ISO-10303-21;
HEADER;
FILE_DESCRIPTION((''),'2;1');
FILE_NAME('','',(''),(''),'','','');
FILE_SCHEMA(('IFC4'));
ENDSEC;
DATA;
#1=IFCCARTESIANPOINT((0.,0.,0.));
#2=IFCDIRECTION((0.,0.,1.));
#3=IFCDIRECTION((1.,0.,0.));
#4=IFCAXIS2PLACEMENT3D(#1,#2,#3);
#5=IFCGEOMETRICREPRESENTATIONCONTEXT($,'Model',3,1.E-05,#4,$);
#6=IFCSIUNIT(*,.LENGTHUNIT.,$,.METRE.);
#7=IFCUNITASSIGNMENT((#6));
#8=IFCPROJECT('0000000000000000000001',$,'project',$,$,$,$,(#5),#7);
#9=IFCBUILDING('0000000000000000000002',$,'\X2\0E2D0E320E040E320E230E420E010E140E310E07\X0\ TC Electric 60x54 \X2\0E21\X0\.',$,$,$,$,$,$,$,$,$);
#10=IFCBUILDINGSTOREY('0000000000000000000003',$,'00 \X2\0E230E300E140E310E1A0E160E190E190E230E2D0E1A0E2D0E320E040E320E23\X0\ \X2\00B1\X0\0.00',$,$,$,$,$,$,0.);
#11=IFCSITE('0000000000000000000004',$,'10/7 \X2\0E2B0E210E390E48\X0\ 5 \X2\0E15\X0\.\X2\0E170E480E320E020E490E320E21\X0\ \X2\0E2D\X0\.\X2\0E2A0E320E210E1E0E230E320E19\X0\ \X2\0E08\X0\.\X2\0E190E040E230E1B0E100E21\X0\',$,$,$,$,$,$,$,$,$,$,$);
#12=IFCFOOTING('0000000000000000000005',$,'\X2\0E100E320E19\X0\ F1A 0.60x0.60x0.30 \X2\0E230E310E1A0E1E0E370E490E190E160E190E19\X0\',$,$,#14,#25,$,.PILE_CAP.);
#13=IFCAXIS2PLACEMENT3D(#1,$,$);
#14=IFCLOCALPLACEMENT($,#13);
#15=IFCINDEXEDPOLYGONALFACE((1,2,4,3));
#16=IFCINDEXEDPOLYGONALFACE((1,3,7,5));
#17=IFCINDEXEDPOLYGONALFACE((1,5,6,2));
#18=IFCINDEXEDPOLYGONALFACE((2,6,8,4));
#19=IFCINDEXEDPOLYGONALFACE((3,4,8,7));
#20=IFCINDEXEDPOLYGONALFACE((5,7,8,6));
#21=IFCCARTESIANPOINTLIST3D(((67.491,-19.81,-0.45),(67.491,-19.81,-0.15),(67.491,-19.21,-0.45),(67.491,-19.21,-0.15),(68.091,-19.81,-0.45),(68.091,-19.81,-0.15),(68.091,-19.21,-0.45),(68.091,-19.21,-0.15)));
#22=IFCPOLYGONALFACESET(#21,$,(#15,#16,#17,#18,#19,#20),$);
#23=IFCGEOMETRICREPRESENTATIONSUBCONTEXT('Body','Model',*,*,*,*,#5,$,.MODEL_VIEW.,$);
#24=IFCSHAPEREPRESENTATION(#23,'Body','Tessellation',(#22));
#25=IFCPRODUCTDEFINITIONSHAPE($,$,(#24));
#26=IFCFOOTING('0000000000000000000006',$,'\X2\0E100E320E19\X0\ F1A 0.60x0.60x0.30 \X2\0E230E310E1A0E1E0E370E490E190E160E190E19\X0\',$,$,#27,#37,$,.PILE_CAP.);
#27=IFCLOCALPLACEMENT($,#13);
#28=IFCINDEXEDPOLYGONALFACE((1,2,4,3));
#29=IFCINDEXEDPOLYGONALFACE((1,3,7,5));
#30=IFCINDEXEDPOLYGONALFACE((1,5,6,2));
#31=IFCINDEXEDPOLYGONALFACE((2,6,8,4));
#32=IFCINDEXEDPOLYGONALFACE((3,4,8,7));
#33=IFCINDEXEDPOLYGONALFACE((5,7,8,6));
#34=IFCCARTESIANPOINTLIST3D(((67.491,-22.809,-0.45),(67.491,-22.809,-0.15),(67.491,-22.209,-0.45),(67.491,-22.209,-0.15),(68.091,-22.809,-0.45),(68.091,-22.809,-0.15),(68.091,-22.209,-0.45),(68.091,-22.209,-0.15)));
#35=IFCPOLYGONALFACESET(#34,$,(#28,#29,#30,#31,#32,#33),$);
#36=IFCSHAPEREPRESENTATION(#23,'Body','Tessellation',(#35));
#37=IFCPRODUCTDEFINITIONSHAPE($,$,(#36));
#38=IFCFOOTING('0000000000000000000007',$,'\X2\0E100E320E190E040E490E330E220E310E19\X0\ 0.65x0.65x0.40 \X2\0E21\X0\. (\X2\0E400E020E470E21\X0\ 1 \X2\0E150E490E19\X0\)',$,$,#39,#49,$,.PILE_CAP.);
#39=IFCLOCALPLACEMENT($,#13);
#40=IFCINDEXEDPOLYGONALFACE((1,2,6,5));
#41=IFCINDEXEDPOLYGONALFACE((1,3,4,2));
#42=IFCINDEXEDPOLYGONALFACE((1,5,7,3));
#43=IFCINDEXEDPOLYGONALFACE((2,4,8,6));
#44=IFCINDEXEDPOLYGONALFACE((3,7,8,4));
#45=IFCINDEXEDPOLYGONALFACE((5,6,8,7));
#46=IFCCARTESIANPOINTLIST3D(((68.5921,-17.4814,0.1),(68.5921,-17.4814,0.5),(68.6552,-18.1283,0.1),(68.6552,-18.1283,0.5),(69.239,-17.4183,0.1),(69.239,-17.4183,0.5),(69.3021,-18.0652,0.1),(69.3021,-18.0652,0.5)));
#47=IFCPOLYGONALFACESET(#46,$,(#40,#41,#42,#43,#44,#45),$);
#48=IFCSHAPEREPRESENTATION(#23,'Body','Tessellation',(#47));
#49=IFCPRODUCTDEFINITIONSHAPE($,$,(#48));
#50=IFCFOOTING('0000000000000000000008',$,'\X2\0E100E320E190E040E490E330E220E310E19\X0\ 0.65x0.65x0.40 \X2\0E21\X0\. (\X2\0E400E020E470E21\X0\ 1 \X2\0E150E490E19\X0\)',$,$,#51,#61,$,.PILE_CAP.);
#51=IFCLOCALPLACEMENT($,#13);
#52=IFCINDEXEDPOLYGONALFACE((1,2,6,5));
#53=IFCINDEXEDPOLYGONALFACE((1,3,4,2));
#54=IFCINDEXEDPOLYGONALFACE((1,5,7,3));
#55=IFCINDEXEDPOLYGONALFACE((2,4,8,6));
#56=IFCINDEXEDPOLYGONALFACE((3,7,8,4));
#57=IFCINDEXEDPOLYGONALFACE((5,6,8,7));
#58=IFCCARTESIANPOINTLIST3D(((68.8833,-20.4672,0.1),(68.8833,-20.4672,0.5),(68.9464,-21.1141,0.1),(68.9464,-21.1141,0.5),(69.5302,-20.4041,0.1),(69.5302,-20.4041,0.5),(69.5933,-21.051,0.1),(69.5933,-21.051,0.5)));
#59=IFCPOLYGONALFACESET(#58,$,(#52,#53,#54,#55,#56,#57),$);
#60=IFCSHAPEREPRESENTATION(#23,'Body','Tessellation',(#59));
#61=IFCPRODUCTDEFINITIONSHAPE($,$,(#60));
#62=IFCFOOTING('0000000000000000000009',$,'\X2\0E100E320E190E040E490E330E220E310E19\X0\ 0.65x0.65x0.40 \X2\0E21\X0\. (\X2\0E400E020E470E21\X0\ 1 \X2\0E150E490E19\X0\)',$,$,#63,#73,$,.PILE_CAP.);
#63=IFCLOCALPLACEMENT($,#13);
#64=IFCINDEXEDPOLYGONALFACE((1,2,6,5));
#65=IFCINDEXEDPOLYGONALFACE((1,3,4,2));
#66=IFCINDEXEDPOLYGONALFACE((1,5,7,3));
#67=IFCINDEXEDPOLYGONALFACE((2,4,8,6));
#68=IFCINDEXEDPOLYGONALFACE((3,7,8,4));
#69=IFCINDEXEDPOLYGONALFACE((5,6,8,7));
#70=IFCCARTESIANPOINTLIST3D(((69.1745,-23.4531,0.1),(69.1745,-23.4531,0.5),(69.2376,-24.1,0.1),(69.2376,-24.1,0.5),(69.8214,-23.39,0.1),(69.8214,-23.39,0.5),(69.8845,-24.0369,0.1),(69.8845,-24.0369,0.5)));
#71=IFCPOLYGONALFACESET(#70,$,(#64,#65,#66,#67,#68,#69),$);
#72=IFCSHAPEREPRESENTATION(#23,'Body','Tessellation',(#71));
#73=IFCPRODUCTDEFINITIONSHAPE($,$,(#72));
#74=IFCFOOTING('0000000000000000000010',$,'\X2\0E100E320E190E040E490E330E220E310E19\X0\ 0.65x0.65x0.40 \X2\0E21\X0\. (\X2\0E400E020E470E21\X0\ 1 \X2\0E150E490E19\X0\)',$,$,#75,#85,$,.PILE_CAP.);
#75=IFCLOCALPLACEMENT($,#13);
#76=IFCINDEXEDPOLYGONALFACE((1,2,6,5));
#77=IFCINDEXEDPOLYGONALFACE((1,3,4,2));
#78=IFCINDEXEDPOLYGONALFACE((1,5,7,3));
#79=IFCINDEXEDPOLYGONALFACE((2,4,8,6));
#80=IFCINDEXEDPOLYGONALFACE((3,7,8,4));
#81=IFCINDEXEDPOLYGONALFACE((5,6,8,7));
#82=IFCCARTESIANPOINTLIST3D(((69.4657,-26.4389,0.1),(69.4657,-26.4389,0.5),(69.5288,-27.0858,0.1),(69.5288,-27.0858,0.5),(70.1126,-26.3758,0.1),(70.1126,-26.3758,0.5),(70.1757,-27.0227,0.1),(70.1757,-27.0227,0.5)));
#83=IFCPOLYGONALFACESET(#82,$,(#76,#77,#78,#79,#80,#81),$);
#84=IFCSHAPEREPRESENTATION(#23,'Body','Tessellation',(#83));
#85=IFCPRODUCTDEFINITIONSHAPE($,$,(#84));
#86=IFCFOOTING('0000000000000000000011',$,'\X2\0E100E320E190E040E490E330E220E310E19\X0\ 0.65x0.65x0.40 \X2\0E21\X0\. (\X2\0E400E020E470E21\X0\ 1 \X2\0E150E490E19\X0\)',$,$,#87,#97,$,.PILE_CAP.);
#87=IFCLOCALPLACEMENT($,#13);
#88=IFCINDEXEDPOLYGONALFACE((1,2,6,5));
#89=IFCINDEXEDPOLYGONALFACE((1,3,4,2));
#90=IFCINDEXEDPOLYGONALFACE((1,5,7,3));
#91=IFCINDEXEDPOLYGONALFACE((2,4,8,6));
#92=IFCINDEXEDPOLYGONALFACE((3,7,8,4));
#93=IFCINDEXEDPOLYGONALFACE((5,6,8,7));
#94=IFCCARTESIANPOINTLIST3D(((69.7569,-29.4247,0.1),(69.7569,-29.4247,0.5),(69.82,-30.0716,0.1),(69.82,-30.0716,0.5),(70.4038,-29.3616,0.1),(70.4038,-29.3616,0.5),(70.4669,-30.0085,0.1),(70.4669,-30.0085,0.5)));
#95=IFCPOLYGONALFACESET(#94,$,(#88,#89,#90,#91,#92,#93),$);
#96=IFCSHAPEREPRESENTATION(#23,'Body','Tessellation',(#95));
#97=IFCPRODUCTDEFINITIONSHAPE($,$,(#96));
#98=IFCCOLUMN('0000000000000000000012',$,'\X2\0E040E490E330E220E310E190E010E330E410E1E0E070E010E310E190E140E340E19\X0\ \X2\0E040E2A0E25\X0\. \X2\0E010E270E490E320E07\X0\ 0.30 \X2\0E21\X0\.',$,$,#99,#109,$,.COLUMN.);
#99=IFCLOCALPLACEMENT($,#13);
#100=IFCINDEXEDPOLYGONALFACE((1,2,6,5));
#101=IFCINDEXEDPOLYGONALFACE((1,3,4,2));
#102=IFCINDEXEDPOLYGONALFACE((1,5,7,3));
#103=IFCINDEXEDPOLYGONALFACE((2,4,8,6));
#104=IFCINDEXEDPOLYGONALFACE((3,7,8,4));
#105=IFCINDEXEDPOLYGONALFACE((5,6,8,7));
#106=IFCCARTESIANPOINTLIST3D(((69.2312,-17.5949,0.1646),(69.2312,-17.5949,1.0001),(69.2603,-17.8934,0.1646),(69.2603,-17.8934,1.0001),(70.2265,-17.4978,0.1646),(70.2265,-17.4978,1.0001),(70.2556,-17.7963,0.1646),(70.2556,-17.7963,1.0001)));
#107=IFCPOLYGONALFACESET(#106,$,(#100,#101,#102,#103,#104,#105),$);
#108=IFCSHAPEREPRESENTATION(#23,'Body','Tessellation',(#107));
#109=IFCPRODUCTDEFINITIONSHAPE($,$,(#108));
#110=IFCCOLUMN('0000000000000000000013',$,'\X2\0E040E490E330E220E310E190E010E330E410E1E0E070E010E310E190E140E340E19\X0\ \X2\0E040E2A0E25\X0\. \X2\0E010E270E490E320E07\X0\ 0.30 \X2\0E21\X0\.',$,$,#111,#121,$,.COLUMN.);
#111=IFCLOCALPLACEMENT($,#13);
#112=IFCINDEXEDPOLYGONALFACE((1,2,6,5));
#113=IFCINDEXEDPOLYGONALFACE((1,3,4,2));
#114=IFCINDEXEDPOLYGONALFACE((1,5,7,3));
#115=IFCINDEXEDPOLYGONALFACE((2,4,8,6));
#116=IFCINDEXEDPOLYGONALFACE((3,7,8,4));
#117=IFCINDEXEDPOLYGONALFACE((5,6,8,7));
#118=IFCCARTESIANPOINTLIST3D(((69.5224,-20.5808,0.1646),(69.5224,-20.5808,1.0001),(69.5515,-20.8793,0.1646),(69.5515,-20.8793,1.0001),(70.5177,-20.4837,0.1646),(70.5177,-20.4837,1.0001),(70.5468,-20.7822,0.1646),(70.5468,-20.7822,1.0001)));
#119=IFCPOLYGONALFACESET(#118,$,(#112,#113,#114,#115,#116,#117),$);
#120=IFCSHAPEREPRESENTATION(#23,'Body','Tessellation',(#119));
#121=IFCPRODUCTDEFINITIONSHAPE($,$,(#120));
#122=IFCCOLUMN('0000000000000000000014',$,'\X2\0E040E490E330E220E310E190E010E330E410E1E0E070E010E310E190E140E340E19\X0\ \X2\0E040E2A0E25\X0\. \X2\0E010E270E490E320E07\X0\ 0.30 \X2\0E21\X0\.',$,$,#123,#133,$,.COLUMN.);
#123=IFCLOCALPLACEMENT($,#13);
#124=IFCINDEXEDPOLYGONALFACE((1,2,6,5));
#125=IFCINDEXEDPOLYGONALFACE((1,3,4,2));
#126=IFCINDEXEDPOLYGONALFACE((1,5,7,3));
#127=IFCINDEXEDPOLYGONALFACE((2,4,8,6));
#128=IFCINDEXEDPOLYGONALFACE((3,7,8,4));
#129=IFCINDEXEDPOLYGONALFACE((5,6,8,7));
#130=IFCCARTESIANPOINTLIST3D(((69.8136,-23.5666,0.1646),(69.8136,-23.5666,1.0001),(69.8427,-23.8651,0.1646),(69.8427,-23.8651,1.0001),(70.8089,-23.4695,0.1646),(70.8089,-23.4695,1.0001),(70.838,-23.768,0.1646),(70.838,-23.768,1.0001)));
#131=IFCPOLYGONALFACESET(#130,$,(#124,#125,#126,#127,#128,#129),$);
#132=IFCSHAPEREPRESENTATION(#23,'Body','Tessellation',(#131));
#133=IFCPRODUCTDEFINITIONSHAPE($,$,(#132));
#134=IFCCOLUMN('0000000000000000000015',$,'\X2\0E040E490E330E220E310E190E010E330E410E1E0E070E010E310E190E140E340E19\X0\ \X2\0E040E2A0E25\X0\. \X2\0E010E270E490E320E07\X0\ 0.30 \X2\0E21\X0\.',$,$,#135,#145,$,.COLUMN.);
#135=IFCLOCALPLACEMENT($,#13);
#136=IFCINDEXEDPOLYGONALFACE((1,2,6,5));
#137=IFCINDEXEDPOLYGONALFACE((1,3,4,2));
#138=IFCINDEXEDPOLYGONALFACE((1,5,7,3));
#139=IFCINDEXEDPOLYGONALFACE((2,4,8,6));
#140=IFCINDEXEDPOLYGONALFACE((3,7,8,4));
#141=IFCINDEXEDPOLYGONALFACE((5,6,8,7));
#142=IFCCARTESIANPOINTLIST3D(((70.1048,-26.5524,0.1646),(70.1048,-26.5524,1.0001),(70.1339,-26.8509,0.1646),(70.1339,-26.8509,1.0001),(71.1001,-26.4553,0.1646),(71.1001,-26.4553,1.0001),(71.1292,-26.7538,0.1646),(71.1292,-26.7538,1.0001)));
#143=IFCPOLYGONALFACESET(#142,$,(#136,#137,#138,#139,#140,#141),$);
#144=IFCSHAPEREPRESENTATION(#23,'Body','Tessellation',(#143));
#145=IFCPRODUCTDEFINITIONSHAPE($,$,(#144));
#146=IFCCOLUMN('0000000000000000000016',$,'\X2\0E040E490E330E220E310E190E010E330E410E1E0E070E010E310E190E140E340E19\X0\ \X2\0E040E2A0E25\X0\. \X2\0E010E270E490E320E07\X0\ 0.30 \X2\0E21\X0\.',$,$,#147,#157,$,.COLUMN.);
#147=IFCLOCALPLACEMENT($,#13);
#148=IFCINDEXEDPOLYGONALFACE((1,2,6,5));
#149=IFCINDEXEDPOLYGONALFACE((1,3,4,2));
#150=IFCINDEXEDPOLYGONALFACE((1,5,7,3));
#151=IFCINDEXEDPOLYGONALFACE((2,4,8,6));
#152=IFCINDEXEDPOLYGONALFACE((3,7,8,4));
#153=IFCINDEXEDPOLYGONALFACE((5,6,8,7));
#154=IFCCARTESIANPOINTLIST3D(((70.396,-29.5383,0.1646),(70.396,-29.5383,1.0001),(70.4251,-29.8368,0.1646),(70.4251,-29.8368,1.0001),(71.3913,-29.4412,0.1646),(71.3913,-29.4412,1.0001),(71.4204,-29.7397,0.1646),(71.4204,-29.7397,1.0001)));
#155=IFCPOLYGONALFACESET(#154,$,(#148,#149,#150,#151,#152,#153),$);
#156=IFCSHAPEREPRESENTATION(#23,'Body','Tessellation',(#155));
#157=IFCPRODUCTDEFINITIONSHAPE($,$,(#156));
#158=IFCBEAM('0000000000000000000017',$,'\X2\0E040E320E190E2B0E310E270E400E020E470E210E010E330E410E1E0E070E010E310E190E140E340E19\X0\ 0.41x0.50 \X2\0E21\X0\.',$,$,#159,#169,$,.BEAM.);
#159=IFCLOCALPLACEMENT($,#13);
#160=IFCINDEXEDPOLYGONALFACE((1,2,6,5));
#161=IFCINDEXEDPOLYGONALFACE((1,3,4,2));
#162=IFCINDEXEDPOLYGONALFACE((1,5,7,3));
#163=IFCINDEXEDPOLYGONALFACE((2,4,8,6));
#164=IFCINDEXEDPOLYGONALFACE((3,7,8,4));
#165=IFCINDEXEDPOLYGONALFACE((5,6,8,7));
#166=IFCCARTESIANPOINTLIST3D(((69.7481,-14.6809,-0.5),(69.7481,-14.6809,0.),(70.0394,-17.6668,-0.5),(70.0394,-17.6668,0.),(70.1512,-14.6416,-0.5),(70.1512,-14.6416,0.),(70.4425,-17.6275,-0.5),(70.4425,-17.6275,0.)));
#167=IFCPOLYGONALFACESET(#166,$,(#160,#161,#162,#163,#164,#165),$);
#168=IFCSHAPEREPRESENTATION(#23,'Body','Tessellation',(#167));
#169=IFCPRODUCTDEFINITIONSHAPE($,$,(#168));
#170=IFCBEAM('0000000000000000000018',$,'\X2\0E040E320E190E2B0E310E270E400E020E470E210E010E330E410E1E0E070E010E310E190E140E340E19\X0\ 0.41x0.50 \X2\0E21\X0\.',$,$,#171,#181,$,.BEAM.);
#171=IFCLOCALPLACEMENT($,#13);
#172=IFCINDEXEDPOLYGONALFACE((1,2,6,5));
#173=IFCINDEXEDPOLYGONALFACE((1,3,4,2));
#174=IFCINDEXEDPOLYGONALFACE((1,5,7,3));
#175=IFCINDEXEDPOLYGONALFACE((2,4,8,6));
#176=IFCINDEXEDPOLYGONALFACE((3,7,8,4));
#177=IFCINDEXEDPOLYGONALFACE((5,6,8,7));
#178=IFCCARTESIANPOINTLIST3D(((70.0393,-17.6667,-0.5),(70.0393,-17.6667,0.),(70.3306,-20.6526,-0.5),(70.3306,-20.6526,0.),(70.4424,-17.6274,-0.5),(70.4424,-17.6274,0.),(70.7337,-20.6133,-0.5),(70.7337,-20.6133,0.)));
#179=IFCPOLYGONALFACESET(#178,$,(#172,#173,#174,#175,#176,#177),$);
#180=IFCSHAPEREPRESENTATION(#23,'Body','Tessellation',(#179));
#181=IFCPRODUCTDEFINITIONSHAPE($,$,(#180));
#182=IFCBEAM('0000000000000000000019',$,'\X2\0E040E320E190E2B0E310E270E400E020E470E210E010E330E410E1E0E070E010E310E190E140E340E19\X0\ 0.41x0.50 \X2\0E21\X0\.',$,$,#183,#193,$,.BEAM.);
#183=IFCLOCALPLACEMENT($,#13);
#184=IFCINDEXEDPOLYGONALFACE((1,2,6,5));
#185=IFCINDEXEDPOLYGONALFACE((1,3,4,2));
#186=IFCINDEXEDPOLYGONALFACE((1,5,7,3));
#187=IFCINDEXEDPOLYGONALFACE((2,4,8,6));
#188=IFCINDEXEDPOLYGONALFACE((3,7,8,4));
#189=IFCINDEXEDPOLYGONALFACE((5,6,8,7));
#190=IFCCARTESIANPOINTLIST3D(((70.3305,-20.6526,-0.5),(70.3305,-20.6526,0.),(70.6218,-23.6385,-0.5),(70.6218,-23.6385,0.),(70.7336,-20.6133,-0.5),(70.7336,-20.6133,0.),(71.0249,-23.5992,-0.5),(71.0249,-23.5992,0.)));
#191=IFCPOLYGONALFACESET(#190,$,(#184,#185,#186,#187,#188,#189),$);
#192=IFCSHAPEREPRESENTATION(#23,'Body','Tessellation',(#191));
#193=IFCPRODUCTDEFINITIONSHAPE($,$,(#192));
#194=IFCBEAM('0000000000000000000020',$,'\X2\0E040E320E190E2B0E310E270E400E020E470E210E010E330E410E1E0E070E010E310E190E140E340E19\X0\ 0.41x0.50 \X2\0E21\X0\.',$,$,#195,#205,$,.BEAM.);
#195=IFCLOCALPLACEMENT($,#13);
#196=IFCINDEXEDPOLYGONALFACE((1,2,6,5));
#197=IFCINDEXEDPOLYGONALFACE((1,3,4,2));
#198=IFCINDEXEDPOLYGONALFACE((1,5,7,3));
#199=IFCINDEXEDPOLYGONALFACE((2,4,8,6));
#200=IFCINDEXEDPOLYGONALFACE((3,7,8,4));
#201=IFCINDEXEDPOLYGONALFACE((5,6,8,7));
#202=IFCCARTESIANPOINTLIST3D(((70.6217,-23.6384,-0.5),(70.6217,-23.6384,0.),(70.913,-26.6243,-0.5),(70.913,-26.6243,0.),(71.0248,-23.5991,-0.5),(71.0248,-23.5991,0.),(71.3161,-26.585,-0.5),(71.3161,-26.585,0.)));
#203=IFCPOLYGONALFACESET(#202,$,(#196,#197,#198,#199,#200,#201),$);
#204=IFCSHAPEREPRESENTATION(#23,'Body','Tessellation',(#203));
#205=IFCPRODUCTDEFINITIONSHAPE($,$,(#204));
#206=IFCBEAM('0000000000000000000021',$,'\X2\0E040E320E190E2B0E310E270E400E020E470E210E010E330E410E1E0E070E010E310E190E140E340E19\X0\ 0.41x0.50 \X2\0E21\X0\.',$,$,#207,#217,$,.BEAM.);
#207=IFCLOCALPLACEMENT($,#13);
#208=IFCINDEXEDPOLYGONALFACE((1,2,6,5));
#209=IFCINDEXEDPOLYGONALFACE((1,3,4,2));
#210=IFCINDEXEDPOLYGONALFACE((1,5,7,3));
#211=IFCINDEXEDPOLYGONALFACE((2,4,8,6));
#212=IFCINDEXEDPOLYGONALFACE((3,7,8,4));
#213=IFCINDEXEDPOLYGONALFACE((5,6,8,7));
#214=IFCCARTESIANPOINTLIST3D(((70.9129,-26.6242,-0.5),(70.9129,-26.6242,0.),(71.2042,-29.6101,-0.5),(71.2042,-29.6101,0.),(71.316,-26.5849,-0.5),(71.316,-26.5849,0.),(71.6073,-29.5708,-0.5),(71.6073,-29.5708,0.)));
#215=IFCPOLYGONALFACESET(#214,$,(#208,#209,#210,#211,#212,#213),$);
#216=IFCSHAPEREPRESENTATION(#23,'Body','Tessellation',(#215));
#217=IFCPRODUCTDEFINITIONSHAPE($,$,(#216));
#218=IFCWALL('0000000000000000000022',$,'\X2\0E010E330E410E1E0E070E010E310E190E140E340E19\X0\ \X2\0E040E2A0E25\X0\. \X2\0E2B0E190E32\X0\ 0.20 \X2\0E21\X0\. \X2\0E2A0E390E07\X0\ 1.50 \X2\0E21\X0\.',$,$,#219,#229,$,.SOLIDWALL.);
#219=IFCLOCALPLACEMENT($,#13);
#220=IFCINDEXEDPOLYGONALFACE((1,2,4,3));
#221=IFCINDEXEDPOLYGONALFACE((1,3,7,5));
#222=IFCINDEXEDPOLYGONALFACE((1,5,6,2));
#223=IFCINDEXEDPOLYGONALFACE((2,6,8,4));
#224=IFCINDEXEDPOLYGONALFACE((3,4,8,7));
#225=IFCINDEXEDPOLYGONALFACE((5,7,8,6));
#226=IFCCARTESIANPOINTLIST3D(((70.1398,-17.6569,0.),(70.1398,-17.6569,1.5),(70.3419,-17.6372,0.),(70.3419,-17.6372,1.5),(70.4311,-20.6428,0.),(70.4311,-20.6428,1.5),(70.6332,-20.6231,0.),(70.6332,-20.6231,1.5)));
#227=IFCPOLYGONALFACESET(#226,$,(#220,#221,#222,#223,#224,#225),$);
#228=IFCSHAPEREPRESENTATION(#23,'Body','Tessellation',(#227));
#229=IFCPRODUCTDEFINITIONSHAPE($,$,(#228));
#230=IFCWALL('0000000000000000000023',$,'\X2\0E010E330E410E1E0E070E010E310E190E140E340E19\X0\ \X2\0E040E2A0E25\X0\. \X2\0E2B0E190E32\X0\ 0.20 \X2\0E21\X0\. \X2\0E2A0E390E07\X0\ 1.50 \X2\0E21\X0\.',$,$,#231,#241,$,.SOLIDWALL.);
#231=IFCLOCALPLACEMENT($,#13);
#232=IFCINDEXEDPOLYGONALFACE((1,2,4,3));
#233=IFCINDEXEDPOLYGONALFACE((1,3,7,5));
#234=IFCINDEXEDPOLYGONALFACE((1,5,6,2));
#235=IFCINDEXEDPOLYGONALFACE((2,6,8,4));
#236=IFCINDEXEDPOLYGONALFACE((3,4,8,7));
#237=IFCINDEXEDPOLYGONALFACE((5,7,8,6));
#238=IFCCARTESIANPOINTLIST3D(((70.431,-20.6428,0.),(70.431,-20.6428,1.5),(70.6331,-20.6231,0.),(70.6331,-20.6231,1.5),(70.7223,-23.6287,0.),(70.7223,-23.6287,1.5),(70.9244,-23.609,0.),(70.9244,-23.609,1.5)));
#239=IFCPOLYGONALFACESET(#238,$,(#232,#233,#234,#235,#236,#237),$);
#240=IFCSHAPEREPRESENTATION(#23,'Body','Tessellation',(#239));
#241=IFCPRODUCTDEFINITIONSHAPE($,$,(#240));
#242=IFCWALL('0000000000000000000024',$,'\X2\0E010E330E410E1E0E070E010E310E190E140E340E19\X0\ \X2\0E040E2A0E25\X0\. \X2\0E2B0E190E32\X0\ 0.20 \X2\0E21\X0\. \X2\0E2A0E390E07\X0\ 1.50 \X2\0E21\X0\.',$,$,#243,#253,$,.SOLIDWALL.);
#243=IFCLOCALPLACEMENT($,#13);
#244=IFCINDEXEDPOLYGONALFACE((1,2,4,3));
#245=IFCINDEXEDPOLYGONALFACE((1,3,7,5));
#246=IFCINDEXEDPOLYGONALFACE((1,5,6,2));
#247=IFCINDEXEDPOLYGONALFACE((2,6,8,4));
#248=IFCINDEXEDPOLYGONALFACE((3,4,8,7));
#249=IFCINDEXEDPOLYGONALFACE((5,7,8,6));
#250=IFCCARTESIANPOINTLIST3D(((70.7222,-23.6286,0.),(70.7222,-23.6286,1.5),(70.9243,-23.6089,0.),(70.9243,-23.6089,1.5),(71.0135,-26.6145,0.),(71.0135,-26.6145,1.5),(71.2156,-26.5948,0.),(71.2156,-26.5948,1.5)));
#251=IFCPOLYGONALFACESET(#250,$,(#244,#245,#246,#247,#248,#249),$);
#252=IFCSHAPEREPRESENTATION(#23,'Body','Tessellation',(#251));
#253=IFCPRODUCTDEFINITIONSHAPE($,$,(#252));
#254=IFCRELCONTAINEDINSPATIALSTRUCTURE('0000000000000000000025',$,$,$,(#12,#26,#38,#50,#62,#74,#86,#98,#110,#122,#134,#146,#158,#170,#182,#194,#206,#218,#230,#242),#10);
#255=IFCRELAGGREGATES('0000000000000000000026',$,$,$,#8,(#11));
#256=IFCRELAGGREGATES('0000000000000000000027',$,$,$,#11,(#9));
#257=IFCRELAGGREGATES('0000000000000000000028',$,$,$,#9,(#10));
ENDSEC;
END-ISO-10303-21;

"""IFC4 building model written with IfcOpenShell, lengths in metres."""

from ifc_helpers import new_model, si_unit, frame, origin, origin_with_axes, origin_2d, place, context, subcontext, project, spatial, rectangle, extrude, element, save


model = new_model("IFC4")

# Units and contexts
model_context = context("Model", 3, precision=1e-05, world=origin_with_axes())
body_context = subcontext(model_context, "Body", "Model", "MODEL_VIEW")
ifc_project = project(units=[si_unit("LENGTHUNIT", "METRE")], contexts=[model_context])

# Site, building, storey
site = spatial("IfcSite", under=ifc_project, Name="10/7 หมู่ 5 ต.ท่าข้าม อ.สามพราน จ.นครปฐม")
building = spatial("IfcBuilding", under=site, Name="อาคารโกดัง TC Electric 60x54 ม.")
storey = spatial("IfcBuildingStorey", under=building, Name="00 ระดับถนนรอบอาคาร ±0.00", Elevation=0.0)

# Footings
for number, where, z_axis, x_axis, name in (
    (1, (67.791, -19.51, -0.45), (0.0, 0.0, 1.0), (1.0, 0.0, 0.0), "ฐาน F1A 0.60x0.60x0.30 รับพื้นถนน"),
    (2, (67.791, -22.509, -0.45), (0.0, 0.0, 1.0), (1.0, 0.0, 0.0), "ฐาน F1A 0.60x0.60x0.30 รับพื้นถนน"),
):
    element("IfcFooting", number, at=place(None, frame(where, z_axis=z_axis, x_axis=x_axis)), inside=storey, Name=name, PredefinedType="PILE_CAP", context=body_context, shape_type="SweptSolid", body=[
        extrude(rectangle(XDim=0.6, YDim=0.6, at=origin_2d()), origin(), (0.0, 0.0, 1.0), 0.3),
    ])
for number, where, z_axis, x_axis, name in (
    (3, (68.9471, -17.7733, 0.1), (0.0, 0.0, 1.0), (-0.9953, -0.0971, 0.0), "ฐานค้ำยัน 0.65x0.65x0.40 ม. (เข็ม 1 ต้น)"),
    (4, (69.2383, -20.7591, 0.1), (0.0, 0.0, 1.0), (-0.9953, -0.0971, 0.0), "ฐานค้ำยัน 0.65x0.65x0.40 ม. (เข็ม 1 ต้น)"),
    (5, (69.5295, -23.745, 0.1), (0.0, 0.0, 1.0), (-0.9953, -0.0971, 0.0), "ฐานค้ำยัน 0.65x0.65x0.40 ม. (เข็ม 1 ต้น)"),
    (6, (69.8207, -26.7308, 0.1), (0.0, 0.0, 1.0), (-0.9953, -0.0971, 0.0), "ฐานค้ำยัน 0.65x0.65x0.40 ม. (เข็ม 1 ต้น)"),
    (7, (70.1119, -29.7166, 0.1), (0.0, 0.0, 1.0), (-0.9953, -0.0971, 0.0), "ฐานค้ำยัน 0.65x0.65x0.40 ม. (เข็ม 1 ต้น)"),
):
    element("IfcFooting", number, at=place(None, frame(where, z_axis=z_axis, x_axis=x_axis)), inside=storey, Name=name, PredefinedType="PILE_CAP", context=body_context, shape_type="SweptSolid", body=[
        extrude(rectangle(XDim=0.65, YDim=0.65, at=origin_2d()), origin(), (0.0, 0.0, 1.0), 0.4),
    ])

# Columns
for number, where, z_axis, x_axis, name in (
    (8, (69.7434, -17.6956, 0.1646), (0.0, 0.0, 1.0), (-0.9953, -0.0971, 0.0), "ค้ำยันกำแพงกันดิน คสล. กว้าง 0.30 ม."),
    (9, (70.0346, -20.6815, 0.1646), (0.0, 0.0, 1.0), (-0.9953, -0.0971, 0.0), "ค้ำยันกำแพงกันดิน คสล. กว้าง 0.30 ม."),
    (10, (70.3258, -23.6673, 0.1646), (0.0, 0.0, 1.0), (-0.9953, -0.0971, 0.0), "ค้ำยันกำแพงกันดิน คสล. กว้าง 0.30 ม."),
    (11, (70.617, -26.6531, 0.1646), (0.0, 0.0, 1.0), (-0.9953, -0.0971, 0.0), "ค้ำยันกำแพงกันดิน คสล. กว้าง 0.30 ม."),
    (12, (70.9082, -29.639, 0.1646), (0.0, 0.0, 1.0), (-0.9953, -0.0971, 0.0), "ค้ำยันกำแพงกันดิน คสล. กว้าง 0.30 ม."),
):
    element("IfcColumn", number, at=place(None, frame(where, z_axis=z_axis, x_axis=x_axis)), inside=storey, Name=name, PredefinedType="COLUMN", context=body_context, shape_type="SweptSolid", body=[
        extrude(rectangle(XDim=1.0, YDim=0.3, at=origin_2d()), origin(), (0.0, 0.0, 1.0), 0.8355),
    ])

# Beams
for number, where, z_axis, x_axis, name in (
    (13, (70.0953, -16.1542, -0.5), (0.0, 0.0, 1.0), (0.0971, -0.9953, 0.0), "คานหัวเข็มกำแพงกันดิน 0.41x0.50 ม."),
    (14, (70.3865, -19.14, -0.5), (0.0, 0.0, 1.0), (0.0971, -0.9953, 0.0), "คานหัวเข็มกำแพงกันดิน 0.41x0.50 ม."),
    (15, (70.6777, -22.1259, -0.5), (0.0, 0.0, 1.0), (0.0971, -0.9953, 0.0), "คานหัวเข็มกำแพงกันดิน 0.41x0.50 ม."),
    (16, (70.9689, -25.1117, -0.5), (0.0, 0.0, 1.0), (0.0971, -0.9953, 0.0), "คานหัวเข็มกำแพงกันดิน 0.41x0.50 ม."),
    (17, (71.2601, -28.0975, -0.5), (0.0, 0.0, 1.0), (0.0971, -0.9953, 0.0), "คานหัวเข็มกำแพงกันดิน 0.41x0.50 ม."),
):
    element("IfcBeam", number, at=place(None, frame(where, z_axis=z_axis, x_axis=x_axis)), inside=storey, Name=name, PredefinedType="BEAM", context=body_context, shape_type="SweptSolid", body=[
        extrude(rectangle(XDim=3.0, YDim=0.405, at=origin_2d()), origin(), (0.0, 0.0, 1.0), 0.5),
    ])

# Walls
for number, where, z_axis, x_axis, name in (
    (18, (70.3865, -19.14, 0.0), (0.0, 0.0, 1.0), (0.0971, -0.9953, 0.0), "กำแพงกันดิน คสล. หนา 0.20 ม. สูง 1.50 ม."),
    (19, (70.6777, -22.1259, 0.0), (0.0, 0.0, 1.0), (0.0971, -0.9953, 0.0), "กำแพงกันดิน คสล. หนา 0.20 ม. สูง 1.50 ม."),
    (20, (70.9689, -25.1117, 0.0), (0.0, 0.0, 1.0), (0.0971, -0.9953, 0.0), "กำแพงกันดิน คสล. หนา 0.20 ม. สูง 1.50 ม."),
):
    element("IfcWall", number, at=place(None, frame(where, z_axis=z_axis, x_axis=x_axis)), inside=storey, Name=name, PredefinedType="SOLIDWALL", context=body_context, shape_type="SweptSolid", body=[
        extrude(rectangle(XDim=3.0, YDim=0.203, at=origin_2d()), origin(), (0.0, 0.0, 1.0), 1.5),
    ])

save(model, "model.ifc")
